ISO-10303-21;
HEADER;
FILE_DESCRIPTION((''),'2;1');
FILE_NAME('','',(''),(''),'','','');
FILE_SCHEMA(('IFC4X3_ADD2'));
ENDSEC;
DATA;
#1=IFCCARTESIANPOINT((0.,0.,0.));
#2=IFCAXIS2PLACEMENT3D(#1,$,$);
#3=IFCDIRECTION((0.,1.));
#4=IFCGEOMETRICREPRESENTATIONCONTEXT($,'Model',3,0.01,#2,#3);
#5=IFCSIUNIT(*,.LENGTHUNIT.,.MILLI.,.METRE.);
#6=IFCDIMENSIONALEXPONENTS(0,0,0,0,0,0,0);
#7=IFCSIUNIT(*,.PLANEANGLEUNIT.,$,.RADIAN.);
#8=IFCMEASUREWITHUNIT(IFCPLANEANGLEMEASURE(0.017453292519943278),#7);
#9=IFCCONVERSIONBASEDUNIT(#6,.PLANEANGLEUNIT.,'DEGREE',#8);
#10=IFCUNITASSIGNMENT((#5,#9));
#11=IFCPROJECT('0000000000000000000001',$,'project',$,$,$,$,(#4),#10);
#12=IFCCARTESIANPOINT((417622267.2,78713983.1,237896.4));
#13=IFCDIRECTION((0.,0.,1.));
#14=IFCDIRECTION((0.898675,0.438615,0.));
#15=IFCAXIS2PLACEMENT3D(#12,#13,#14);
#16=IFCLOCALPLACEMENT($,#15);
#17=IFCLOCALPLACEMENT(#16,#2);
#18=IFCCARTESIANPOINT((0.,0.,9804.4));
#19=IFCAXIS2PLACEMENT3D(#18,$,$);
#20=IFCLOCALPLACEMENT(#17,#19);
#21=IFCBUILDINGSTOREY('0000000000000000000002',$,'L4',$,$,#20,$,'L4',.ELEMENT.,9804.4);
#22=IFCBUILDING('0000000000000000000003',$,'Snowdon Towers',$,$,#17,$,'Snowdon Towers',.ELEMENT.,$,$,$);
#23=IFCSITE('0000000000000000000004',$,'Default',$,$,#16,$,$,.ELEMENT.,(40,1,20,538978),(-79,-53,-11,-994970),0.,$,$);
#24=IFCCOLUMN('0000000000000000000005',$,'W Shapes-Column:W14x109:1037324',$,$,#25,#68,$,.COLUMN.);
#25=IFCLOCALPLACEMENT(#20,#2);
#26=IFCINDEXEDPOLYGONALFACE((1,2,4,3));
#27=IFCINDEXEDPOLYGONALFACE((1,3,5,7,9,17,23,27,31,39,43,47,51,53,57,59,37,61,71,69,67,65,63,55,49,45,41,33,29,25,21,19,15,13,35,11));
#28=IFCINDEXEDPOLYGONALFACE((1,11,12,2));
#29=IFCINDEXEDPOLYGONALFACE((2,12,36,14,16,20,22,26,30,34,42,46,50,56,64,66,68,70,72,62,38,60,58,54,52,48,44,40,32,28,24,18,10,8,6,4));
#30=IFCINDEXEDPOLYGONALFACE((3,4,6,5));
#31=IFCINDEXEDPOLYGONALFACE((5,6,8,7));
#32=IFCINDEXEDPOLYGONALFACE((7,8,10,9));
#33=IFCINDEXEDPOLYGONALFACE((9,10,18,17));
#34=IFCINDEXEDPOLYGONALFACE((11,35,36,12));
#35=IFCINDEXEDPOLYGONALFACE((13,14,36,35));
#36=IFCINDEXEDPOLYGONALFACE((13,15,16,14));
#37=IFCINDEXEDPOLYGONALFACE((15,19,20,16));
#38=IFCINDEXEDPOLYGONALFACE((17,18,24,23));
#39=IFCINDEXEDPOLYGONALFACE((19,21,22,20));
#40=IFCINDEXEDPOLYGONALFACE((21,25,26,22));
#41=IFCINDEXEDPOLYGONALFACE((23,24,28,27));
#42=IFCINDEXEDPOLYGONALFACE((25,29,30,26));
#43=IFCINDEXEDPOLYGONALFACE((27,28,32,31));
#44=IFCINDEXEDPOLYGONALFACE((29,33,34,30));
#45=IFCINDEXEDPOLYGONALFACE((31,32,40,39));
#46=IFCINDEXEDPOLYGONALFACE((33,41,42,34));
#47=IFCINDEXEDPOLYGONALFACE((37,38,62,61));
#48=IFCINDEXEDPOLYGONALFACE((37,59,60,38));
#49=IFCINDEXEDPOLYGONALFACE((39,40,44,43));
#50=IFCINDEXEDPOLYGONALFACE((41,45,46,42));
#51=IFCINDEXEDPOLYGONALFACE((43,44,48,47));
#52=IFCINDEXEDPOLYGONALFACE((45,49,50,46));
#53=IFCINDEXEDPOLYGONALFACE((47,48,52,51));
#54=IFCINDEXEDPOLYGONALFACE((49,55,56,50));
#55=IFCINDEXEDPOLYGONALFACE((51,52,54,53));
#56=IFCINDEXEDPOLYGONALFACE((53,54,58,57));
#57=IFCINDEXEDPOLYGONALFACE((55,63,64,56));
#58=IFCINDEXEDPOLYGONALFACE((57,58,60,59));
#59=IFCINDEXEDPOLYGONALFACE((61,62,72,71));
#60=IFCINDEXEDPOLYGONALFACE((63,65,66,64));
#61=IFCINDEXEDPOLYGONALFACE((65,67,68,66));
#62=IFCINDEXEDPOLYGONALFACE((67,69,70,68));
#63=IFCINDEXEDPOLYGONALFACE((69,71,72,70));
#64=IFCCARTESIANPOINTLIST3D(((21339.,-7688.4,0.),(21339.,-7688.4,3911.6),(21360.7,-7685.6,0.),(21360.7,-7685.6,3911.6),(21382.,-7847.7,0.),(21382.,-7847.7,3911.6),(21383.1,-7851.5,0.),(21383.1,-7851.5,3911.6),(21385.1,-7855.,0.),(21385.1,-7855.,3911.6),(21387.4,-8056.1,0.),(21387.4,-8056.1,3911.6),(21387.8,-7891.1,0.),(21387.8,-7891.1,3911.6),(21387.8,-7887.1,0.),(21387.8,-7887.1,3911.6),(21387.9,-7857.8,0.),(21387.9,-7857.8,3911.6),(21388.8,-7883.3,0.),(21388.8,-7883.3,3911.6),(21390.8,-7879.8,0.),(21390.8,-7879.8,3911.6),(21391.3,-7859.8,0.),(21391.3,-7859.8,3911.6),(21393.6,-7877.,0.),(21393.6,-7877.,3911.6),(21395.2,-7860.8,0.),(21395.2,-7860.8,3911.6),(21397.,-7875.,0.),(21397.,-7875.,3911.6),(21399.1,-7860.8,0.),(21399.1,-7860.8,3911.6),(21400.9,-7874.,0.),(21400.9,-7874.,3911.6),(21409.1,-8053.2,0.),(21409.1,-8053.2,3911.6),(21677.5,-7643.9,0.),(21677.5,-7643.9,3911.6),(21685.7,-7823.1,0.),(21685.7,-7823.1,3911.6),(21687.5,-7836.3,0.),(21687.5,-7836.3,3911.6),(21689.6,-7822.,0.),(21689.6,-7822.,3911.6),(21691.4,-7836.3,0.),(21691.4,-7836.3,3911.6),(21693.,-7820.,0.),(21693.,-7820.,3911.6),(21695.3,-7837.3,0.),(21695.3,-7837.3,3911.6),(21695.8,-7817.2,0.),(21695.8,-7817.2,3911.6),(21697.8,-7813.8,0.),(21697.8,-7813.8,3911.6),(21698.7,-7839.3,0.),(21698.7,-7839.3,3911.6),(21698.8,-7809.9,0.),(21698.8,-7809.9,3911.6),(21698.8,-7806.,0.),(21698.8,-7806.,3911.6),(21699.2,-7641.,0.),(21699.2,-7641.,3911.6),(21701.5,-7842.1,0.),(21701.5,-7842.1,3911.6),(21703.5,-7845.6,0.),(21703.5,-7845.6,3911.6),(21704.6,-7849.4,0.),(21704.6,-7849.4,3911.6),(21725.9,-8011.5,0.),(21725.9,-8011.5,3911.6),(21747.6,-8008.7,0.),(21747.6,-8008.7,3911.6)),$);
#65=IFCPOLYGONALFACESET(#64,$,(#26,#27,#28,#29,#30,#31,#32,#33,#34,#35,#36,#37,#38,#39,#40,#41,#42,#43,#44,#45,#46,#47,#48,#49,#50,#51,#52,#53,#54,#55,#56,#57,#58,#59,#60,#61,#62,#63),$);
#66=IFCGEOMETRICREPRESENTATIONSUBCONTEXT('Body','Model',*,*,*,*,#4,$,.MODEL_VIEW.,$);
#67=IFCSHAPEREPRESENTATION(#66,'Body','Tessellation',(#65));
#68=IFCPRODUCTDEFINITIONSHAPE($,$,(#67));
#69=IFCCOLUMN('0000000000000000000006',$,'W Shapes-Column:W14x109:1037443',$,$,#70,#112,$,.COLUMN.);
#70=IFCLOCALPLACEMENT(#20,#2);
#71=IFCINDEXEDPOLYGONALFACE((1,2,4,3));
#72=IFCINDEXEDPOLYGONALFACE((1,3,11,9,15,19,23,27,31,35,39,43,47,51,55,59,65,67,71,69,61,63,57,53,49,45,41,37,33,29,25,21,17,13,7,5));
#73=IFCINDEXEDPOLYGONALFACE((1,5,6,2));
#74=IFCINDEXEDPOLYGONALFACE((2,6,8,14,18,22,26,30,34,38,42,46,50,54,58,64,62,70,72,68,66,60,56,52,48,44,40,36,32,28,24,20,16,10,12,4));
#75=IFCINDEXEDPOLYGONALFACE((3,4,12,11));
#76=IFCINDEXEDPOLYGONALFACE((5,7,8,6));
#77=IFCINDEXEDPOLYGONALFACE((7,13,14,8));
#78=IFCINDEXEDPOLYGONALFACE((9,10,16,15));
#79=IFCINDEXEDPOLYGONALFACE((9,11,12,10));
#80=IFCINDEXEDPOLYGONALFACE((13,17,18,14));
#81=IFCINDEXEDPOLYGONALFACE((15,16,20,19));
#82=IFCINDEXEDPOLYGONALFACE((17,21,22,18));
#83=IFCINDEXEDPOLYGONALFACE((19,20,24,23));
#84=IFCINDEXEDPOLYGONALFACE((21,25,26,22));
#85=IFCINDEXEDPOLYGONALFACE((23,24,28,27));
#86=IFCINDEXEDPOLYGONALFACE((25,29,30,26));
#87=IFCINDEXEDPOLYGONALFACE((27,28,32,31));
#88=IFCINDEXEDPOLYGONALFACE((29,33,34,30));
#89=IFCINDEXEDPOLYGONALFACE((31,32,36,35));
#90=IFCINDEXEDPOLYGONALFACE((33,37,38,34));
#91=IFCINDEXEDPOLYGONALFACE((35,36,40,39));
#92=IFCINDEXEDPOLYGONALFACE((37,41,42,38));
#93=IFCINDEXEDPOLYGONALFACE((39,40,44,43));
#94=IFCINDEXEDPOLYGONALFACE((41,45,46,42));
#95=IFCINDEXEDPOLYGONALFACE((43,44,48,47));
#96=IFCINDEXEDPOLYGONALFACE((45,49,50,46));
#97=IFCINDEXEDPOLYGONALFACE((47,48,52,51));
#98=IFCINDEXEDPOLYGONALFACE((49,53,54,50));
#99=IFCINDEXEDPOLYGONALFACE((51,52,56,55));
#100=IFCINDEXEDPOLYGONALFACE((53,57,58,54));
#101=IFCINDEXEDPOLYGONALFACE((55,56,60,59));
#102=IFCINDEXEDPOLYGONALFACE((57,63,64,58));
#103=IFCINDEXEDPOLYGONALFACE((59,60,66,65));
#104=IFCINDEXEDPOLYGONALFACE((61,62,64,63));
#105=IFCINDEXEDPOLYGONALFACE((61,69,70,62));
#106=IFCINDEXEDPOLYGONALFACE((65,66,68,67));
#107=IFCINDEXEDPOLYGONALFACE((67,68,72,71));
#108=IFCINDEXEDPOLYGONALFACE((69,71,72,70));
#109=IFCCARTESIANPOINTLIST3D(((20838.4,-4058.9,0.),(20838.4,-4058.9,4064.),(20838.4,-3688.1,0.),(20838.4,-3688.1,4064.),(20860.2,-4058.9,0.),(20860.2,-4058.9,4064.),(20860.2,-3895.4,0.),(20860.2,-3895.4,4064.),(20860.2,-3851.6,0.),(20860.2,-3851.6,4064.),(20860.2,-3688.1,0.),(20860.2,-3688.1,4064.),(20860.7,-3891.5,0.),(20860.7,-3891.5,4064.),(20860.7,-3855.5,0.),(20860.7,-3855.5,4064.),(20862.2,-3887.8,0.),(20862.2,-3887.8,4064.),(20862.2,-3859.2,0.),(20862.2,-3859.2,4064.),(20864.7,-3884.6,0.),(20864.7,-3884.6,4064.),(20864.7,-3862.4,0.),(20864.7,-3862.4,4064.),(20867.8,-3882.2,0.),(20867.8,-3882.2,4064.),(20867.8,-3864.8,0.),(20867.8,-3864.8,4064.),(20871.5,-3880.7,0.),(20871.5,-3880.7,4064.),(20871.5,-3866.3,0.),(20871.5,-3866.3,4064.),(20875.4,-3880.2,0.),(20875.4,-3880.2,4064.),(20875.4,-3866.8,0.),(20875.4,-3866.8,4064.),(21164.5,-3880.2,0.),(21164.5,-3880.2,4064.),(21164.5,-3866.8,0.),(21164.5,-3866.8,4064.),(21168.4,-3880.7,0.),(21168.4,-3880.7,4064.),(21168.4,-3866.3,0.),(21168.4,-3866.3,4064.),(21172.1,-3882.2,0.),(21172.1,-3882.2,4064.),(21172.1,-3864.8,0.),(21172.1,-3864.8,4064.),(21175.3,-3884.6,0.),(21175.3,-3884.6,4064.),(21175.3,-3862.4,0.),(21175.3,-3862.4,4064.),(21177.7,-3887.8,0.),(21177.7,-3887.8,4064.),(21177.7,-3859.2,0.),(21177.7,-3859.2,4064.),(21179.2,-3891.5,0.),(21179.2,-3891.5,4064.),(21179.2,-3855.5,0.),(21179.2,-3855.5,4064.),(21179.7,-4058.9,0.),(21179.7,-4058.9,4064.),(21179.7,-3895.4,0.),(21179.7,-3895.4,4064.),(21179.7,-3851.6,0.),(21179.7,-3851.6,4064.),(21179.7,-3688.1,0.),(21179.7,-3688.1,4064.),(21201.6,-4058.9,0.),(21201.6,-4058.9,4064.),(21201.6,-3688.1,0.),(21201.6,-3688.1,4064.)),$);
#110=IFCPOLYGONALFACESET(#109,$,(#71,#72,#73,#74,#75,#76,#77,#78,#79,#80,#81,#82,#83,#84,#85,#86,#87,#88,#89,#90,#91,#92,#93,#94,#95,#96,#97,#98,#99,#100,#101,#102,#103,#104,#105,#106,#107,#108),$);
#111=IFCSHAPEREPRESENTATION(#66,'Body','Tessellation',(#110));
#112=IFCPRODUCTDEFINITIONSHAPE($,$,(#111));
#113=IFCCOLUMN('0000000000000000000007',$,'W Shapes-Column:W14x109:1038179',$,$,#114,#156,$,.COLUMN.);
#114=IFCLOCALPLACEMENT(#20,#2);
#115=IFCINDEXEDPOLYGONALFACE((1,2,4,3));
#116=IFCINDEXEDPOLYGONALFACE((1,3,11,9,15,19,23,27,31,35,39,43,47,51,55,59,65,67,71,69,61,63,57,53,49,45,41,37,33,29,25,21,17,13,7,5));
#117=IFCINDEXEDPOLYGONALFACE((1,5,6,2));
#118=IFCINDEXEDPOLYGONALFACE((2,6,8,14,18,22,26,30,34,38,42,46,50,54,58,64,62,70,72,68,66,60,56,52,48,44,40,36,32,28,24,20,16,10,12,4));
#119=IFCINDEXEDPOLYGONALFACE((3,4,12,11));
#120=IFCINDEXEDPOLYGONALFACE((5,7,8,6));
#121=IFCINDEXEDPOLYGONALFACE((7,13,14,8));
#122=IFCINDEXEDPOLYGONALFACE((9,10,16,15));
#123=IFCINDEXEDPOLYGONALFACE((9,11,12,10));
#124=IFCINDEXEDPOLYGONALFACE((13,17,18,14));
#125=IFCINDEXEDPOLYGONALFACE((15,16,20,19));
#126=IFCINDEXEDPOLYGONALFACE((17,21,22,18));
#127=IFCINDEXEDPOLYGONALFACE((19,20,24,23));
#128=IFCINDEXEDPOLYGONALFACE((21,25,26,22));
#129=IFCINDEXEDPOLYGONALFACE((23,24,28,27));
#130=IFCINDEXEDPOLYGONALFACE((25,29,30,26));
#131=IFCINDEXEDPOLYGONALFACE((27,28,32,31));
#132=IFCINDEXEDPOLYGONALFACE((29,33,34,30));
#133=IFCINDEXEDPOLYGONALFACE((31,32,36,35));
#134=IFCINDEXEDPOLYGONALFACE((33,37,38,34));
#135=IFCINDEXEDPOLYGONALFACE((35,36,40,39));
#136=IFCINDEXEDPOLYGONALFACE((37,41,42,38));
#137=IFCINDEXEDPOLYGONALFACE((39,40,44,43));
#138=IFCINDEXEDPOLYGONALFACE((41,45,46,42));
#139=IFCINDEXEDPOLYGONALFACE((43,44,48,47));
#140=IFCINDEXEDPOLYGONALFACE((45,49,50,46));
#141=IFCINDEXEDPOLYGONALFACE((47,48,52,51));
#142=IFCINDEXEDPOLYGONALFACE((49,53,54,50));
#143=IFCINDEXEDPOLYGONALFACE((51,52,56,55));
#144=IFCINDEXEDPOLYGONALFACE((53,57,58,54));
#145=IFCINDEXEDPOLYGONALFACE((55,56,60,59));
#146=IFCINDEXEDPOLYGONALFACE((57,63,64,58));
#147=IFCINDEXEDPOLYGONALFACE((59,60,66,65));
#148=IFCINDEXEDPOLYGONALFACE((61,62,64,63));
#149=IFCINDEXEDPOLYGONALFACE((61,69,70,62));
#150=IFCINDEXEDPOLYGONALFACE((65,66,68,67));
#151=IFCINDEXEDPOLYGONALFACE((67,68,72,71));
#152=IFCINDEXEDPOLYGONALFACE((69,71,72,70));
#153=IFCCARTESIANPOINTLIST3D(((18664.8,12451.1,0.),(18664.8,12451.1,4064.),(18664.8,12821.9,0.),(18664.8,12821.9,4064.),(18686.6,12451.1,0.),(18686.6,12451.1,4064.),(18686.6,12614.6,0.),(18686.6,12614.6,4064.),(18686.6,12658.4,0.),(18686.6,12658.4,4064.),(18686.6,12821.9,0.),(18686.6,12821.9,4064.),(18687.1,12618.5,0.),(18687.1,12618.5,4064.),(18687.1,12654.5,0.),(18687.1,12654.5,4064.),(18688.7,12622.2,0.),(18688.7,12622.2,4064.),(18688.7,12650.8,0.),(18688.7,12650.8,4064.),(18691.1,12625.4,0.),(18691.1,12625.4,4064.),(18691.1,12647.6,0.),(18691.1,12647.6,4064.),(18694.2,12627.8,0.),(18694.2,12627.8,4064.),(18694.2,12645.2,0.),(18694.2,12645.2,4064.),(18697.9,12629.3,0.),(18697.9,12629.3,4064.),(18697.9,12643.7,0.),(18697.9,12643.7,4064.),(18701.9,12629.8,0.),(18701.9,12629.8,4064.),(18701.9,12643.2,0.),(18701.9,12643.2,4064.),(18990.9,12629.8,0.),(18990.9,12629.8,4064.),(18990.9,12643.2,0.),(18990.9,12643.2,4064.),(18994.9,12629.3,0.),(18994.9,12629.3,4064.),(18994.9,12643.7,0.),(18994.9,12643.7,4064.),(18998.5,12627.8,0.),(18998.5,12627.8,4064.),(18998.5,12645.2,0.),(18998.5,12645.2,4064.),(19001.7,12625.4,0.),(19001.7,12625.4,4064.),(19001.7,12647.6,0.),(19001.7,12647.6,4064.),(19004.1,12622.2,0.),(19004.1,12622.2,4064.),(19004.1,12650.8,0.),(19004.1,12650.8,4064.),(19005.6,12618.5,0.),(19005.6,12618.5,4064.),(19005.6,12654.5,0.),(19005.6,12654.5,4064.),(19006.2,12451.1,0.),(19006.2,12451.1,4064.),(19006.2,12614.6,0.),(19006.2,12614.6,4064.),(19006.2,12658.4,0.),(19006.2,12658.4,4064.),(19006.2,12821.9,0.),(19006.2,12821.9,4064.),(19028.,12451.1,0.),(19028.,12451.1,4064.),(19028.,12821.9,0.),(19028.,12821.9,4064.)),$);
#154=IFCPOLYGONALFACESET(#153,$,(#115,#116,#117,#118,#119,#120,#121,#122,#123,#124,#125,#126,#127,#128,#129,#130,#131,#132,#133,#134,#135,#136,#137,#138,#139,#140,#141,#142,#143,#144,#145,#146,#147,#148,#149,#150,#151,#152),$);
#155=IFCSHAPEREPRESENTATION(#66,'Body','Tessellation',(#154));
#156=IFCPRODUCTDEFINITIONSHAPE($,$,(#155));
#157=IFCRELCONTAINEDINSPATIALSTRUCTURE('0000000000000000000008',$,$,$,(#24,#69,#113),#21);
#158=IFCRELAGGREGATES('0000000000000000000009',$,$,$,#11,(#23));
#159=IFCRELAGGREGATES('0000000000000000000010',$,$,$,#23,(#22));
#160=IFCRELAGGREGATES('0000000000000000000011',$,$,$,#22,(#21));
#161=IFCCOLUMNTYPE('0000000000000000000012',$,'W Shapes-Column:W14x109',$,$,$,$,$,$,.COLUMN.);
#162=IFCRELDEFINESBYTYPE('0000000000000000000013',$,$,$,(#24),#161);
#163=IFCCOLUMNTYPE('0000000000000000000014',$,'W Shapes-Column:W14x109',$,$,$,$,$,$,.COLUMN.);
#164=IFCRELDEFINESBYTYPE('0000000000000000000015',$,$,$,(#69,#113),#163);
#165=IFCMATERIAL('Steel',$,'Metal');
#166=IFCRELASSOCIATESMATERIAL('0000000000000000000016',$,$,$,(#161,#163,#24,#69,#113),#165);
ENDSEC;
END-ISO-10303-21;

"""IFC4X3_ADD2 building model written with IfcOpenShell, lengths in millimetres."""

from ifc_helpers import new_model, entity, si_unit, converted_unit, direction, frame, frame_2d, origin, place, context, subcontext, project, spatial, i_section, extrude, source, transform, mapped, material, material_profile, profile_set, profile_usage, type_object, type_shapes, element, save


model = new_model("IFC4X3_ADD2")

# Units and contexts
model_context = context("Model", 3, precision=0.01, world=origin(), true_north=direction((0.0, 1.0)))
body_context = subcontext(model_context, "Body", "Model", "MODEL_VIEW")
ifc_project = project(units=[si_unit("LENGTHUNIT", "METRE", prefix="MILLI"), converted_unit("PLANEANGLEUNIT", "DEGREE", entity("IfcPlaneAngleMeasure", 0.017453292519943278), si_unit("PLANEANGLEUNIT", "RADIAN"), dimensions=[0, 0, 0, 0, 0, 0, 0])], contexts=[model_context])

# Site, building, storey
site_placement = place(None, frame((417622267.2, 78713983.1, 237896.4), z_axis=(0.0, 0.0, 1.0), x_axis=(0.898675, 0.438615, 0.0)))
site = spatial("IfcSite", under=ifc_project, at=site_placement, Name="Default", CompositionType="ELEMENT", RefLatitude=(40, 1, 20, 538978), RefLongitude=(-79, -53, -11, -994970), RefElevation=0.0)
building_placement = place(site_placement, origin())
building = spatial("IfcBuilding", under=site, at=building_placement, Name="Snowdon Towers", LongName="Snowdon Towers", CompositionType="ELEMENT")
storey_placement = place(building_placement, frame((0.0, 0.0, 9804.4)))
storey = spatial("IfcBuildingStorey", under=building, at=storey_placement, Name="L4", LongName="L4", CompositionType="ELEMENT", Elevation=9804.4)

# Columns
ifc_material_1 = material(Name="Steel", Category="Metal")
ifc_material_profile_1 = material_profile(ifc_material_1, i_section(OverallWidth=370.8, OverallDepth=363.2, WebThickness=13.3, FlangeThickness=21.8, FilletRadius=15.2, at=frame_2d((0.0, 0.0), x_axis=(1.0, 0.0))), Name="W14x109")
ifc_profile_set_1 = profile_set([ifc_material_profile_1], Name="W14x109")
ifc_profile_usage_1 = profile_usage(ifc_profile_set_1)
column_type_1 = type_object("IfcColumnType", Name="W Shapes-Column:W14x109", PredefinedType="COLUMN", material=ifc_profile_set_1)
shared_shape_1 = source(origin(), body_context, "Body", "SweptSolid", [
    extrude(i_section(OverallWidth=370.8, OverallDepth=363.2, WebThickness=13.3, FlangeThickness=21.8, FilletRadius=15.2, at=frame_2d((0.0, 0.0), x_axis=(1.0, 0.0))), frame((0.0, 0.0, 9804.4), z_axis=(0.0, 0.0, 1.0), x_axis=(-1.0, 0.0, 0.0)), (0.0, 0.0, 1.0), 3911.6),
])
type_shapes(column_type_1, [shared_shape_1])
column_placement = place(storey_placement, frame((21543.3, -7848.5, -9804.4), z_axis=(0.0, 0.0, 1.0), x_axis=(-0.130526, 0.991445, 0.0)))
element("IfcColumn", 1, at=column_placement, inside=storey, type_object=column_type_1, material=ifc_profile_usage_1, Name="W Shapes-Column:W14x109:1037324", PredefinedType="COLUMN", context=body_context, shape_type="MappedRepresentation", body=[
    mapped(shared_shape_1, transform((0.0, 0.0, 0.0), scale=1.0)),
])
column_type_2 = type_object("IfcColumnType", Name="W Shapes-Column:W14x109", PredefinedType="COLUMN", material=ifc_profile_set_1)
shared_shape_2 = source(origin(), body_context, "Body", "SweptSolid", [
    extrude(i_section(OverallWidth=370.8, OverallDepth=363.2, WebThickness=13.3, FlangeThickness=21.8, FilletRadius=15.2, at=frame_2d((0.0, 0.0), x_axis=(1.0, 0.0))), frame((0.0, 0.0, 9804.4), z_axis=(0.0, 0.0, 1.0), x_axis=(-1.0, 0.0, 0.0)), (0.0, 0.0, 1.0), 4064.0),
])
type_shapes(column_type_2, [shared_shape_2])
for number, where, z_axis, x_axis, name in (
    (2, (21020.0, -3873.5, -9804.4), (0.0, 0.0, 1.0), (0.0, 1.0, 0.0), "W Shapes-Column:W14x109:1037443"),
    (3, (18846.4, 12636.5, -9804.4), (0.0, 0.0, 1.0), (0.0, 1.0, 0.0), "W Shapes-Column:W14x109:1038179"),
):
    element("IfcColumn", number, at=place(storey_placement, frame(where, z_axis=z_axis, x_axis=x_axis)), inside=storey, type_object=column_type_2, material=ifc_profile_usage_1, Name=name, PredefinedType="COLUMN", context=body_context, shape_type="MappedRepresentation", body=[
        mapped(shared_shape_2, transform((0.0, 0.0, 0.0), scale=1.0)),
    ])

save(model, "model.ifc")
